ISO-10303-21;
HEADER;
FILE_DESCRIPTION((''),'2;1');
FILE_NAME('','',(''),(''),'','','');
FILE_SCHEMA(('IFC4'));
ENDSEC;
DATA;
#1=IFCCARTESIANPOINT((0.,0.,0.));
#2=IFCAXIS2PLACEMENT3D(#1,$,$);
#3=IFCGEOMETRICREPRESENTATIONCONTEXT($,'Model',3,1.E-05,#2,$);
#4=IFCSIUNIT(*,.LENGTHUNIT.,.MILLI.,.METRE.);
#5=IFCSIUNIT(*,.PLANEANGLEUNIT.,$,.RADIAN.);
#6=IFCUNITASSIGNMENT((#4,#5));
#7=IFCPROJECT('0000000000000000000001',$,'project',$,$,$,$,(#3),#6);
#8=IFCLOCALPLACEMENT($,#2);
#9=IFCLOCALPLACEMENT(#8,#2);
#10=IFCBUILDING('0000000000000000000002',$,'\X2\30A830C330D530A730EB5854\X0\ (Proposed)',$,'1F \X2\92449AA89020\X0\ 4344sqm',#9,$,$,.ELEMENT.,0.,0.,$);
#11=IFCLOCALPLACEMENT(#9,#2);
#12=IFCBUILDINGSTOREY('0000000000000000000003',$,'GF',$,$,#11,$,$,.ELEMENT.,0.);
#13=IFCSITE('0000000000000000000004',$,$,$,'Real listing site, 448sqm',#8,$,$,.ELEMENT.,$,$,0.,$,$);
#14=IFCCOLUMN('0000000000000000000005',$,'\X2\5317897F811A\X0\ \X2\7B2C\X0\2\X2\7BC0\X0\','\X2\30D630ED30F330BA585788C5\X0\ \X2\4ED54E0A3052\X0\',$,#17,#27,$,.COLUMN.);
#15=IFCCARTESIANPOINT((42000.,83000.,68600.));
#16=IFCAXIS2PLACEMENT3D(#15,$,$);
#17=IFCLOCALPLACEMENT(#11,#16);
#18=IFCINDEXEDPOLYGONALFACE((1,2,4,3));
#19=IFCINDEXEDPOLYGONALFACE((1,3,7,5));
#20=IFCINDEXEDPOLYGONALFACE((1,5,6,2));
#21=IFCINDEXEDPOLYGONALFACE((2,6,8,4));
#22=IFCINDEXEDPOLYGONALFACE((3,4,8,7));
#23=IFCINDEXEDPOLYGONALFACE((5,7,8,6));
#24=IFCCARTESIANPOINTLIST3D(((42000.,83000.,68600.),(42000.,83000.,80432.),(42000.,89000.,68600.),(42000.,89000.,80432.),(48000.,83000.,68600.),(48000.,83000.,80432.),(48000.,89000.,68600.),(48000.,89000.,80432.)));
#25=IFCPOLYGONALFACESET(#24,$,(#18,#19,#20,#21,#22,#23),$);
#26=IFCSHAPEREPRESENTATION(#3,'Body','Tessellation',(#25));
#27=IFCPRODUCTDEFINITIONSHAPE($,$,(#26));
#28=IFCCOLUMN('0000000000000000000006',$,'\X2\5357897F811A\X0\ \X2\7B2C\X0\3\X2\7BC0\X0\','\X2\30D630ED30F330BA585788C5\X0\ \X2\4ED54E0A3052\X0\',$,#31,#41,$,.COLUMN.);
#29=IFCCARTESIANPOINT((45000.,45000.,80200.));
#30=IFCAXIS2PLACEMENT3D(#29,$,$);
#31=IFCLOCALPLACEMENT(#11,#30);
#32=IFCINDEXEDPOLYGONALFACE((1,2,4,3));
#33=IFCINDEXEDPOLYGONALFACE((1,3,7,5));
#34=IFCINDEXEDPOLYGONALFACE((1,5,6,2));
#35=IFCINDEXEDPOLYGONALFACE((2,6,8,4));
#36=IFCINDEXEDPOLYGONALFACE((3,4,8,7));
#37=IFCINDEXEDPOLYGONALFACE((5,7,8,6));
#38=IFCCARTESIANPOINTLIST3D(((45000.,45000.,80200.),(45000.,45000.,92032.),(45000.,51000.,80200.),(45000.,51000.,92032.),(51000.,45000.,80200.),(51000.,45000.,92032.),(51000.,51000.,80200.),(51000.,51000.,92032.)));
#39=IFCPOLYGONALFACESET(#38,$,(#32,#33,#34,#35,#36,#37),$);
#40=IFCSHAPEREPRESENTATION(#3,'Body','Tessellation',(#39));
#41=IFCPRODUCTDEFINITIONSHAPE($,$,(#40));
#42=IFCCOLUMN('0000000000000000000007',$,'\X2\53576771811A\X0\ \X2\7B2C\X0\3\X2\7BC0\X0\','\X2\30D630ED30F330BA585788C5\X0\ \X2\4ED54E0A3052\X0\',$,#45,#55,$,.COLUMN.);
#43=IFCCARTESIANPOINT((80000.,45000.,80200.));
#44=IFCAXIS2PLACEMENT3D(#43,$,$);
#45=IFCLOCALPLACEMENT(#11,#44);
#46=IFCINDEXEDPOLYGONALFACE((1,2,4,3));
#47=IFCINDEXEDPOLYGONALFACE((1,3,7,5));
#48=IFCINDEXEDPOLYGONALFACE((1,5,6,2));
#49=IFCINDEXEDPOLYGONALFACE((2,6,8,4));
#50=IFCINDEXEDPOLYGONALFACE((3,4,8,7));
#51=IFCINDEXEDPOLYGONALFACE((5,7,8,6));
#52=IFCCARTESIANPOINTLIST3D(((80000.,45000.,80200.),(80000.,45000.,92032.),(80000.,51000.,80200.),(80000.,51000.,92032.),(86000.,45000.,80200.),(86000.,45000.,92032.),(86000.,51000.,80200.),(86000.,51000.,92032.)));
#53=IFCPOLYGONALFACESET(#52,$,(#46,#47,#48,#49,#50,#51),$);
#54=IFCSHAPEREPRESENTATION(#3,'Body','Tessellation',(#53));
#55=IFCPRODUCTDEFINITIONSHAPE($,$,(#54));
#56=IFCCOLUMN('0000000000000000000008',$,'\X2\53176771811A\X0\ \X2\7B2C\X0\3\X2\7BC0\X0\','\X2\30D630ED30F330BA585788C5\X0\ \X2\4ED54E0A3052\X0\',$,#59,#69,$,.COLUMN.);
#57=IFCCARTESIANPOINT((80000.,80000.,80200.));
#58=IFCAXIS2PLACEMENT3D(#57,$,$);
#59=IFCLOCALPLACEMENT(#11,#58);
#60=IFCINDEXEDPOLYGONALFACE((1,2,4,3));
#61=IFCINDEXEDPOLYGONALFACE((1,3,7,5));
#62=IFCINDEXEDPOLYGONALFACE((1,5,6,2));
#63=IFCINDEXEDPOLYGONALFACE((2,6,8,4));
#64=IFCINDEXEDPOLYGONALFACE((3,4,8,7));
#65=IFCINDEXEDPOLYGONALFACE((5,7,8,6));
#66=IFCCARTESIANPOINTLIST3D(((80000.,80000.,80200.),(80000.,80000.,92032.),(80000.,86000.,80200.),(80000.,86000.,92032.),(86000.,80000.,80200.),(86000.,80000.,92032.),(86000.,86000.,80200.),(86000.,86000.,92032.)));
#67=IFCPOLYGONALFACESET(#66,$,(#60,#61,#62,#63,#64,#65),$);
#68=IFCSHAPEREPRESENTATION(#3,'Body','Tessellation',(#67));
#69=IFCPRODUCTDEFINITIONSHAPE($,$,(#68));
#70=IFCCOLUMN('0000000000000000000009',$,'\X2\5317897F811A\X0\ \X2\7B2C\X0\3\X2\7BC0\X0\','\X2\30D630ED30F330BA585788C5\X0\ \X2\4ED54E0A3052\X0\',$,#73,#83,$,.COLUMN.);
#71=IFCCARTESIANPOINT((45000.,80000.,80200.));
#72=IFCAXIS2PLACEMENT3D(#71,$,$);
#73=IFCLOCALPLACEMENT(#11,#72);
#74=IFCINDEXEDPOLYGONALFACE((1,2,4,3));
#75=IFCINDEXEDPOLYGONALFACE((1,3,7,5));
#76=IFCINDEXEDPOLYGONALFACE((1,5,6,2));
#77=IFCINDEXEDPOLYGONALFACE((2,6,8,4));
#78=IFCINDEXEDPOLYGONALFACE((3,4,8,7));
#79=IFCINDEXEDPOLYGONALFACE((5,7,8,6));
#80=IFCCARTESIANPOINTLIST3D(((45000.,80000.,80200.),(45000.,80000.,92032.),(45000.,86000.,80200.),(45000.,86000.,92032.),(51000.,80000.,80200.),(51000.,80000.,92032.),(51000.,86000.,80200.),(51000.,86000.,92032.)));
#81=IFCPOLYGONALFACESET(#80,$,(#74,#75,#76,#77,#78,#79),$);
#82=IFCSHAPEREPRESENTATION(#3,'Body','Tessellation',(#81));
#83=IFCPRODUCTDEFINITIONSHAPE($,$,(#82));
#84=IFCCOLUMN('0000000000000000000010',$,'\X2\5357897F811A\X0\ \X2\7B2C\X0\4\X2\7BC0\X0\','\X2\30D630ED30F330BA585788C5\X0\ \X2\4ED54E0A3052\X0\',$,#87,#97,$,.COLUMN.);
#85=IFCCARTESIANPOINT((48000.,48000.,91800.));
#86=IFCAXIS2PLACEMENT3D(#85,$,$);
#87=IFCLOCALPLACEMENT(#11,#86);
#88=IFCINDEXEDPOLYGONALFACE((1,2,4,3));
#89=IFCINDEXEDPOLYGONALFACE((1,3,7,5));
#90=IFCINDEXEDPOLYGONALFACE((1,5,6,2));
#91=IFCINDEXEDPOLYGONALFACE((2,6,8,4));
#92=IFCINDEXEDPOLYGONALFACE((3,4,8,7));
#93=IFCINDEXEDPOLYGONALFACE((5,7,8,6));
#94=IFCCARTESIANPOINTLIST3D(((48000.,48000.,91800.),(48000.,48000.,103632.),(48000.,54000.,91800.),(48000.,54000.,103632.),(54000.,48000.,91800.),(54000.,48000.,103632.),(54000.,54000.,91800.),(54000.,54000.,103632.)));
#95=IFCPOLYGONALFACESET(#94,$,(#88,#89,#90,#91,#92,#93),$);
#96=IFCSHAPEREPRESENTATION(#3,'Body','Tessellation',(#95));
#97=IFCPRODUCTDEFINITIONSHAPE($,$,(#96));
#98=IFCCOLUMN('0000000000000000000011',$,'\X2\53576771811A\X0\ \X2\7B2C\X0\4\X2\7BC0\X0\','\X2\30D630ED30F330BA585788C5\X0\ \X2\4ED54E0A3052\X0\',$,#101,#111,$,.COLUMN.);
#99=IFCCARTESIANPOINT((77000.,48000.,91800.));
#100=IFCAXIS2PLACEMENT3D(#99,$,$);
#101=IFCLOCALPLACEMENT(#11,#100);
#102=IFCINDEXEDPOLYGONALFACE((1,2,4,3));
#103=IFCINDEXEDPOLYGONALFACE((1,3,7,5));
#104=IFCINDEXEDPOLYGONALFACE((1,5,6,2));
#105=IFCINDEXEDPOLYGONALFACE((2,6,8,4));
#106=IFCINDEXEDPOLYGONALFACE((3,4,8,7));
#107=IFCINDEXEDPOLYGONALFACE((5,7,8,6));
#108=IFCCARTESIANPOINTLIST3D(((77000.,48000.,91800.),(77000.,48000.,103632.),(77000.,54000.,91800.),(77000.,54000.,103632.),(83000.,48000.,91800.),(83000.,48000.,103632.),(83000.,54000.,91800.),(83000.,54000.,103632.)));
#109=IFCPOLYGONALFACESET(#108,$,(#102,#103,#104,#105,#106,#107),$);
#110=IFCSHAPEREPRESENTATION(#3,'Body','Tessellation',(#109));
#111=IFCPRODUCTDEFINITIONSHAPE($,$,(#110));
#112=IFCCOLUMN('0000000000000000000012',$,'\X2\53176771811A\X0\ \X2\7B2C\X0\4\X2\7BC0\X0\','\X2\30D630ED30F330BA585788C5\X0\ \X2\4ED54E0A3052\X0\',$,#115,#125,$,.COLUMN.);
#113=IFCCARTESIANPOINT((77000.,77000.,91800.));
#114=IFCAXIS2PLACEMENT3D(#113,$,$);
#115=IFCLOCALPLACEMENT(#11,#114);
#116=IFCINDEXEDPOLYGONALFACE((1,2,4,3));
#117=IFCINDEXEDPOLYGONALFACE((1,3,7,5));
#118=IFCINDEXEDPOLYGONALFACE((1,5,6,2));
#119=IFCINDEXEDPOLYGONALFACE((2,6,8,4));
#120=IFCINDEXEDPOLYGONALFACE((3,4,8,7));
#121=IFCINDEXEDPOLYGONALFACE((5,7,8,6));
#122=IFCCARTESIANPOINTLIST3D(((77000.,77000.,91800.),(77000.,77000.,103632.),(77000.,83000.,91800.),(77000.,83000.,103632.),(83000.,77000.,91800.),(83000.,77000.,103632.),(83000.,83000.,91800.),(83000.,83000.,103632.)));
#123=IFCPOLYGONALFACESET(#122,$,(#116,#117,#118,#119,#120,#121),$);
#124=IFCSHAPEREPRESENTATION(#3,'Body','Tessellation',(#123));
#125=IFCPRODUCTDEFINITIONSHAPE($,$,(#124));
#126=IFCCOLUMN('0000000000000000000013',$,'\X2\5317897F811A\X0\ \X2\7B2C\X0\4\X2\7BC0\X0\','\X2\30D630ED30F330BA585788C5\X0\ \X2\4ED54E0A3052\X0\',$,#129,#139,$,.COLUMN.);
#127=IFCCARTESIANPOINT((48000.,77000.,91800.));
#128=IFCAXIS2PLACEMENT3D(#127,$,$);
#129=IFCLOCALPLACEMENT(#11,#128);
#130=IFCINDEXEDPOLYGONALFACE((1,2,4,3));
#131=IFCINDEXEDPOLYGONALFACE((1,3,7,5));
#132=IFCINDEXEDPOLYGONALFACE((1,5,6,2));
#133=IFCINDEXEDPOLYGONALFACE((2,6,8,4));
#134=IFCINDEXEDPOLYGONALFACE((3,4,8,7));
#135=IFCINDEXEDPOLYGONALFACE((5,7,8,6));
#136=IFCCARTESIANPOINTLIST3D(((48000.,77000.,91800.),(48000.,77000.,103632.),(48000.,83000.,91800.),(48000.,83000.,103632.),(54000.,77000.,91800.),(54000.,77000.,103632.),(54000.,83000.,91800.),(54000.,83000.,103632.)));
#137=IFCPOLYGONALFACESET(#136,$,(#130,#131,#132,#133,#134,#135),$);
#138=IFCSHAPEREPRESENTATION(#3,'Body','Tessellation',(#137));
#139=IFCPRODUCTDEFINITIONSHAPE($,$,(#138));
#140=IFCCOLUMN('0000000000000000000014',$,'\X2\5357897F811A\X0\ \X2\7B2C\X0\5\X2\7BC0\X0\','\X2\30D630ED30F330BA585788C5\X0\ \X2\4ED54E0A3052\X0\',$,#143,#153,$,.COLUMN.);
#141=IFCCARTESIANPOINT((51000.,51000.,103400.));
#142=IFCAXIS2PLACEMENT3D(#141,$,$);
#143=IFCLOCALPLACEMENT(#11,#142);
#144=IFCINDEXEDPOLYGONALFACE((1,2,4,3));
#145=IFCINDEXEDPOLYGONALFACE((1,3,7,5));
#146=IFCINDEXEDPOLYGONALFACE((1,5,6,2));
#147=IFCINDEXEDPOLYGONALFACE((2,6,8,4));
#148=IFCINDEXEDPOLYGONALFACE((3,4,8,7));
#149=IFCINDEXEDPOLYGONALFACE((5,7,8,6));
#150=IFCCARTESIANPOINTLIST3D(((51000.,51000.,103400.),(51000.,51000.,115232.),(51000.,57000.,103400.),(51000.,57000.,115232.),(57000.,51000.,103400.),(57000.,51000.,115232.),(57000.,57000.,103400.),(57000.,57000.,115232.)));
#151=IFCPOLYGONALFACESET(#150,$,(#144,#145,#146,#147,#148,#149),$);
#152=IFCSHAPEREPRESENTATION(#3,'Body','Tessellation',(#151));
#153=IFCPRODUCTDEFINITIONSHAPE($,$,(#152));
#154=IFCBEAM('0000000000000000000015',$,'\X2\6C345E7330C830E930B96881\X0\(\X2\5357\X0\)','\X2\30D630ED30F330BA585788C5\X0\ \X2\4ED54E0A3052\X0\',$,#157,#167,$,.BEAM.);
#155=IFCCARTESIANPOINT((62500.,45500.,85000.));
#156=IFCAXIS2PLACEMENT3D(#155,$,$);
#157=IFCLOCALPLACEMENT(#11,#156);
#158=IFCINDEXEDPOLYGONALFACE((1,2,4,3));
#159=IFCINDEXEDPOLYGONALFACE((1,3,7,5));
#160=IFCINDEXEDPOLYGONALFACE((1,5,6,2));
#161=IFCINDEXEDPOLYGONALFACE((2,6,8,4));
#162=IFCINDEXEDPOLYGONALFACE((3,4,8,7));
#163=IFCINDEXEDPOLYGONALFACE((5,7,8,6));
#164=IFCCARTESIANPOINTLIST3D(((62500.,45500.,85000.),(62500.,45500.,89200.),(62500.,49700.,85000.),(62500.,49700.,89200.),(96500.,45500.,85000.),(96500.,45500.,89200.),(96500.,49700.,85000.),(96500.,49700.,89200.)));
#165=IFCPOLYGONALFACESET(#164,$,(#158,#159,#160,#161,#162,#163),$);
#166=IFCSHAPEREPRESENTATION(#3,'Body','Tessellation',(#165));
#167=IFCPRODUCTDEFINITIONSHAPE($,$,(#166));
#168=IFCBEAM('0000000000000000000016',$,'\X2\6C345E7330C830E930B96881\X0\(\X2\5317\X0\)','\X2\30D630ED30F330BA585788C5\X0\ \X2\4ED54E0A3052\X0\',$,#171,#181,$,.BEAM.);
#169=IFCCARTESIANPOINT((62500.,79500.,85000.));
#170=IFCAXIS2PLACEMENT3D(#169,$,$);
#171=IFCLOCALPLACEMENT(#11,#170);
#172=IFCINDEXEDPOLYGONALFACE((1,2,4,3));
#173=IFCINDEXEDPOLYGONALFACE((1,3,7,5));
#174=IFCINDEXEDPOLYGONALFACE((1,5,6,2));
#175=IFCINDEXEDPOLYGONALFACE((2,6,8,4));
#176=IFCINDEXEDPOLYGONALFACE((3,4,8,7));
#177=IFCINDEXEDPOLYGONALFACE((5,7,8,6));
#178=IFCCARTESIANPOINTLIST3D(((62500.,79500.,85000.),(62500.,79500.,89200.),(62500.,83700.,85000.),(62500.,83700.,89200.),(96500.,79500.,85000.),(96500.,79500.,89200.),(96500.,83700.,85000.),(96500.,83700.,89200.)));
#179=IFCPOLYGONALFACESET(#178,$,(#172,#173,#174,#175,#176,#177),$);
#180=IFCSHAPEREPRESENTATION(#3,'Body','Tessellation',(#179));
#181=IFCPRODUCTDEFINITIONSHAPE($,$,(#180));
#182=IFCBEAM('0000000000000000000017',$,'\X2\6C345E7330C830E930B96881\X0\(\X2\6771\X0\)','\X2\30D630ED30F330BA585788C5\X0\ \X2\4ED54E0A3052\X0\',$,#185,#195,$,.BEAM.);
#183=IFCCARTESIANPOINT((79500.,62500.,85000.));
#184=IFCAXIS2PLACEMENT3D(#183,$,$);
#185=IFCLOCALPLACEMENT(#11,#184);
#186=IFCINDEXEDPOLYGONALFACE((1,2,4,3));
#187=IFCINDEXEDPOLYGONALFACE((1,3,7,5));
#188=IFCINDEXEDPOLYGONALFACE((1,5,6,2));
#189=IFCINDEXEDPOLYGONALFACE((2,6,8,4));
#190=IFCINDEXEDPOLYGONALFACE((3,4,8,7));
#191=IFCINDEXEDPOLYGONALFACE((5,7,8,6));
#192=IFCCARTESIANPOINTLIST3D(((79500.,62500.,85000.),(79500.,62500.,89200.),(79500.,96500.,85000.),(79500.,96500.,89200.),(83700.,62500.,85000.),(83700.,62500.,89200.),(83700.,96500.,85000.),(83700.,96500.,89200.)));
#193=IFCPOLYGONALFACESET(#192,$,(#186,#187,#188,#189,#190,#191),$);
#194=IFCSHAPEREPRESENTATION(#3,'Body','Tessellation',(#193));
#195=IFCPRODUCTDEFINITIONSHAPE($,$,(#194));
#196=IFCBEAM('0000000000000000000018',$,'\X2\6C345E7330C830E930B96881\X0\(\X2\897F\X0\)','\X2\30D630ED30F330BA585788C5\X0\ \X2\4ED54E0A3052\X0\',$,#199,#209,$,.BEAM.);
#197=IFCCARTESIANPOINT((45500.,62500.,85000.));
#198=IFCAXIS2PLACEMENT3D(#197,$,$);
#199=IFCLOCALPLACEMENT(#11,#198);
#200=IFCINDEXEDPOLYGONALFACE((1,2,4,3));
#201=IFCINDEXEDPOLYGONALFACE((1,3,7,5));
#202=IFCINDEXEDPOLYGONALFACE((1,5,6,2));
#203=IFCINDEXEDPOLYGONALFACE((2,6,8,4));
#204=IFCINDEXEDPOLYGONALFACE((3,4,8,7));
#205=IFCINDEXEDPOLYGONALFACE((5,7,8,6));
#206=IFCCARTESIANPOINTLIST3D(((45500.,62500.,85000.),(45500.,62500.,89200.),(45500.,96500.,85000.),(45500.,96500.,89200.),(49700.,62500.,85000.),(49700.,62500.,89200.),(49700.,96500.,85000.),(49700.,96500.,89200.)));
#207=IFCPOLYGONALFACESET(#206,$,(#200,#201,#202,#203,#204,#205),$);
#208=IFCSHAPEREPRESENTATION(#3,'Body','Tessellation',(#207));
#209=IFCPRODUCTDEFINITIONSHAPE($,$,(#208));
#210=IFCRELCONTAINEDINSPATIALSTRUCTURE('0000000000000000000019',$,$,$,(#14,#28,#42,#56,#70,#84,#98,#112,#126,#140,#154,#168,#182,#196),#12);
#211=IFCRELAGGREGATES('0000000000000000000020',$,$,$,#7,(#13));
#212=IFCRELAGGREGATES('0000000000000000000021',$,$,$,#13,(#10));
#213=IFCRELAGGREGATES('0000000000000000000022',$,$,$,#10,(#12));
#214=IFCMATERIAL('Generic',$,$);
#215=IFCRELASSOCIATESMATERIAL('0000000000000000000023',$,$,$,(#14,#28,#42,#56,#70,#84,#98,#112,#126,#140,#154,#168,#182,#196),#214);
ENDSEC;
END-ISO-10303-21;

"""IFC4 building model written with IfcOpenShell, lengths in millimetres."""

from ifc_helpers import new_model, si_unit, frame, frame_2d, origin, place, context, project, spatial, rectangle, extrude, material, element, save


model = new_model("IFC4")

# Units and contexts
model_context = context("Model", 3, precision=1e-05, world=origin())
ifc_project = project(units=[si_unit("LENGTHUNIT", "METRE", prefix="MILLI"), si_unit("PLANEANGLEUNIT", "RADIAN")], contexts=[model_context])

# Site, building, storey
site_placement = place(None, origin())
site = spatial("IfcSite", under=ifc_project, at=site_placement, ObjectType="Real listing site, 448sqm", CompositionType="ELEMENT", RefElevation=0.0)
building_placement = place(site_placement, origin())
building = spatial("IfcBuilding", under=site, at=building_placement, Name="エッフェル塔 (Proposed)", ObjectType="1F 鉄骨造 4344sqm", CompositionType="ELEMENT", ElevationOfRefHeight=0.0, ElevationOfTerrain=0.0)
storey_placement = place(building_placement, origin())
storey = spatial("IfcBuildingStorey", under=building, at=storey_placement, Name="GF", CompositionType="ELEMENT", Elevation=0.0)

# Columns
ifc_material = material(Name="Generic")
column_1_placement = place(storey_placement, frame((42000.0, 83000.0, 68600.0)))
element("IfcColumn", 1, at=column_1_placement, inside=storey, material=ifc_material, Name="北西脚 第2節", Description="ブロンズ塗装 仕上げ", PredefinedType="COLUMN", context=model_context, shape_type="SweptSolid", body=[
    extrude(rectangle(XDim=6000.0, YDim=6000.0, at=frame_2d((3000.0, 3000.0))), frame((42000.0, 83000.0, 68600.0)), (0.0, 0.0, 1.0), 11832.0),
])
column_2_placement = place(storey_placement, frame((45000.0, 45000.0, 80200.0)))
element("IfcColumn", 2, at=column_2_placement, inside=storey, material=ifc_material, Name="南西脚 第3節", Description="ブロンズ塗装 仕上げ", PredefinedType="COLUMN", context=model_context, shape_type="SweptSolid", body=[
    extrude(rectangle(XDim=6000.0, YDim=6000.0, at=frame_2d((3000.0, 3000.0))), frame((45000.0, 45000.0, 80200.0)), (0.0, 0.0, 1.0), 11832.0),
])
column_3_placement = place(storey_placement, frame((80000.0, 45000.0, 80200.0)))
element("IfcColumn", 3, at=column_3_placement, inside=storey, material=ifc_material, Name="南東脚 第3節", Description="ブロンズ塗装 仕上げ", PredefinedType="COLUMN", context=model_context, shape_type="SweptSolid", body=[
    extrude(rectangle(XDim=6000.0, YDim=6000.0, at=frame_2d((3000.0, 3000.0))), frame((80000.0, 45000.0, 80200.0)), (0.0, 0.0, 1.0), 11832.0),
])
column_4_placement = place(storey_placement, frame((80000.0, 80000.0, 80200.0)))
element("IfcColumn", 4, at=column_4_placement, inside=storey, material=ifc_material, Name="北東脚 第3節", Description="ブロンズ塗装 仕上げ", PredefinedType="COLUMN", context=model_context, shape_type="SweptSolid", body=[
    extrude(rectangle(XDim=6000.0, YDim=6000.0, at=frame_2d((3000.0, 3000.0))), frame((80000.0, 80000.0, 80200.0)), (0.0, 0.0, 1.0), 11832.0),
])
column_5_placement = place(storey_placement, frame((45000.0, 80000.0, 80200.0)))
element("IfcColumn", 5, at=column_5_placement, inside=storey, material=ifc_material, Name="北西脚 第3節", Description="ブロンズ塗装 仕上げ", PredefinedType="COLUMN", context=model_context, shape_type="SweptSolid", body=[
    extrude(rectangle(XDim=6000.0, YDim=6000.0, at=frame_2d((3000.0, 3000.0))), frame((45000.0, 80000.0, 80200.0)), (0.0, 0.0, 1.0), 11832.0),
])
column_6_placement = place(storey_placement, frame((48000.0, 48000.0, 91800.0)))
element("IfcColumn", 6, at=column_6_placement, inside=storey, material=ifc_material, Name="南西脚 第4節", Description="ブロンズ塗装 仕上げ", PredefinedType="COLUMN", context=model_context, shape_type="SweptSolid", body=[
    extrude(rectangle(XDim=6000.0, YDim=6000.0, at=frame_2d((3000.0, 3000.0))), frame((48000.0, 48000.0, 91800.0)), (0.0, 0.0, 1.0), 11832.0),
])
column_7_placement = place(storey_placement, frame((77000.0, 48000.0, 91800.0)))
element("IfcColumn", 7, at=column_7_placement, inside=storey, material=ifc_material, Name="南東脚 第4節", Description="ブロンズ塗装 仕上げ", PredefinedType="COLUMN", context=model_context, shape_type="SweptSolid", body=[
    extrude(rectangle(XDim=6000.0, YDim=6000.0, at=frame_2d((3000.0, 3000.0))), frame((77000.0, 48000.0, 91800.0)), (0.0, 0.0, 1.0), 11832.0),
])
column_8_placement = place(storey_placement, frame((77000.0, 77000.0, 91800.0)))
element("IfcColumn", 8, at=column_8_placement, inside=storey, material=ifc_material, Name="北東脚 第4節", Description="ブロンズ塗装 仕上げ", PredefinedType="COLUMN", context=model_context, shape_type="SweptSolid", body=[
    extrude(rectangle(XDim=6000.0, YDim=6000.0, at=frame_2d((3000.0, 3000.0))), frame((77000.0, 77000.0, 91800.0)), (0.0, 0.0, 1.0), 11832.0),
])
column_9_placement = place(storey_placement, frame((48000.0, 77000.0, 91800.0)))
element("IfcColumn", 9, at=column_9_placement, inside=storey, material=ifc_material, Name="北西脚 第4節", Description="ブロンズ塗装 仕上げ", PredefinedType="COLUMN", context=model_context, shape_type="SweptSolid", body=[
    extrude(rectangle(XDim=6000.0, YDim=6000.0, at=frame_2d((3000.0, 3000.0))), frame((48000.0, 77000.0, 91800.0)), (0.0, 0.0, 1.0), 11832.0),
])
column_10_placement = place(storey_placement, frame((51000.0, 51000.0, 103400.0)))
element("IfcColumn", 10, at=column_10_placement, inside=storey, material=ifc_material, Name="南西脚 第5節", Description="ブロンズ塗装 仕上げ", PredefinedType="COLUMN", context=model_context, shape_type="SweptSolid", body=[
    extrude(rectangle(XDim=6000.0, YDim=6000.0, at=frame_2d((3000.0, 3000.0))), frame((51000.0, 51000.0, 103400.0)), (0.0, 0.0, 1.0), 11832.0),
])

# Beams
beam_1_placement = place(storey_placement, frame((62500.0, 45500.0, 85000.0)))
element("IfcBeam", 11, at=beam_1_placement, inside=storey, material=ifc_material, Name="水平トラス梁(南)", Description="ブロンズ塗装 仕上げ", PredefinedType="BEAM", context=model_context, shape_type="SweptSolid", body=[
    extrude(rectangle(XDim=34000.0, YDim=4200.0, at=frame_2d((17000.0, 2100.0))), frame((62500.0, 45500.0, 85000.0)), (0.0, 0.0, 1.0), 4200.0),
])
beam_2_placement = place(storey_placement, frame((62500.0, 79500.0, 85000.0)))
element("IfcBeam", 12, at=beam_2_placement, inside=storey, material=ifc_material, Name="水平トラス梁(北)", Description="ブロンズ塗装 仕上げ", PredefinedType="BEAM", context=model_context, shape_type="SweptSolid", body=[
    extrude(rectangle(XDim=34000.0, YDim=4200.0, at=frame_2d((17000.0, 2100.0))), frame((62500.0, 79500.0, 85000.0)), (0.0, 0.0, 1.0), 4200.0),
])
beam_3_placement = place(storey_placement, frame((79500.0, 62500.0, 85000.0)))
element("IfcBeam", 13, at=beam_3_placement, inside=storey, material=ifc_material, Name="水平トラス梁(東)", Description="ブロンズ塗装 仕上げ", PredefinedType="BEAM", context=model_context, shape_type="SweptSolid", body=[
    extrude(rectangle(XDim=4200.0, YDim=34000.0, at=frame_2d((2100.0, 17000.0))), frame((79500.0, 62500.0, 85000.0)), (0.0, 0.0, 1.0), 4200.0),
])
beam_4_placement = place(storey_placement, frame((45500.0, 62500.0, 85000.0)))
element("IfcBeam", 14, at=beam_4_placement, inside=storey, material=ifc_material, Name="水平トラス梁(西)", Description="ブロンズ塗装 仕上げ", PredefinedType="BEAM", context=model_context, shape_type="SweptSolid", body=[
    extrude(rectangle(XDim=4200.0, YDim=34000.0, at=frame_2d((2100.0, 17000.0))), frame((45500.0, 62500.0, 85000.0)), (0.0, 0.0, 1.0), 4200.0),
])

save(model, "model.ifc")
